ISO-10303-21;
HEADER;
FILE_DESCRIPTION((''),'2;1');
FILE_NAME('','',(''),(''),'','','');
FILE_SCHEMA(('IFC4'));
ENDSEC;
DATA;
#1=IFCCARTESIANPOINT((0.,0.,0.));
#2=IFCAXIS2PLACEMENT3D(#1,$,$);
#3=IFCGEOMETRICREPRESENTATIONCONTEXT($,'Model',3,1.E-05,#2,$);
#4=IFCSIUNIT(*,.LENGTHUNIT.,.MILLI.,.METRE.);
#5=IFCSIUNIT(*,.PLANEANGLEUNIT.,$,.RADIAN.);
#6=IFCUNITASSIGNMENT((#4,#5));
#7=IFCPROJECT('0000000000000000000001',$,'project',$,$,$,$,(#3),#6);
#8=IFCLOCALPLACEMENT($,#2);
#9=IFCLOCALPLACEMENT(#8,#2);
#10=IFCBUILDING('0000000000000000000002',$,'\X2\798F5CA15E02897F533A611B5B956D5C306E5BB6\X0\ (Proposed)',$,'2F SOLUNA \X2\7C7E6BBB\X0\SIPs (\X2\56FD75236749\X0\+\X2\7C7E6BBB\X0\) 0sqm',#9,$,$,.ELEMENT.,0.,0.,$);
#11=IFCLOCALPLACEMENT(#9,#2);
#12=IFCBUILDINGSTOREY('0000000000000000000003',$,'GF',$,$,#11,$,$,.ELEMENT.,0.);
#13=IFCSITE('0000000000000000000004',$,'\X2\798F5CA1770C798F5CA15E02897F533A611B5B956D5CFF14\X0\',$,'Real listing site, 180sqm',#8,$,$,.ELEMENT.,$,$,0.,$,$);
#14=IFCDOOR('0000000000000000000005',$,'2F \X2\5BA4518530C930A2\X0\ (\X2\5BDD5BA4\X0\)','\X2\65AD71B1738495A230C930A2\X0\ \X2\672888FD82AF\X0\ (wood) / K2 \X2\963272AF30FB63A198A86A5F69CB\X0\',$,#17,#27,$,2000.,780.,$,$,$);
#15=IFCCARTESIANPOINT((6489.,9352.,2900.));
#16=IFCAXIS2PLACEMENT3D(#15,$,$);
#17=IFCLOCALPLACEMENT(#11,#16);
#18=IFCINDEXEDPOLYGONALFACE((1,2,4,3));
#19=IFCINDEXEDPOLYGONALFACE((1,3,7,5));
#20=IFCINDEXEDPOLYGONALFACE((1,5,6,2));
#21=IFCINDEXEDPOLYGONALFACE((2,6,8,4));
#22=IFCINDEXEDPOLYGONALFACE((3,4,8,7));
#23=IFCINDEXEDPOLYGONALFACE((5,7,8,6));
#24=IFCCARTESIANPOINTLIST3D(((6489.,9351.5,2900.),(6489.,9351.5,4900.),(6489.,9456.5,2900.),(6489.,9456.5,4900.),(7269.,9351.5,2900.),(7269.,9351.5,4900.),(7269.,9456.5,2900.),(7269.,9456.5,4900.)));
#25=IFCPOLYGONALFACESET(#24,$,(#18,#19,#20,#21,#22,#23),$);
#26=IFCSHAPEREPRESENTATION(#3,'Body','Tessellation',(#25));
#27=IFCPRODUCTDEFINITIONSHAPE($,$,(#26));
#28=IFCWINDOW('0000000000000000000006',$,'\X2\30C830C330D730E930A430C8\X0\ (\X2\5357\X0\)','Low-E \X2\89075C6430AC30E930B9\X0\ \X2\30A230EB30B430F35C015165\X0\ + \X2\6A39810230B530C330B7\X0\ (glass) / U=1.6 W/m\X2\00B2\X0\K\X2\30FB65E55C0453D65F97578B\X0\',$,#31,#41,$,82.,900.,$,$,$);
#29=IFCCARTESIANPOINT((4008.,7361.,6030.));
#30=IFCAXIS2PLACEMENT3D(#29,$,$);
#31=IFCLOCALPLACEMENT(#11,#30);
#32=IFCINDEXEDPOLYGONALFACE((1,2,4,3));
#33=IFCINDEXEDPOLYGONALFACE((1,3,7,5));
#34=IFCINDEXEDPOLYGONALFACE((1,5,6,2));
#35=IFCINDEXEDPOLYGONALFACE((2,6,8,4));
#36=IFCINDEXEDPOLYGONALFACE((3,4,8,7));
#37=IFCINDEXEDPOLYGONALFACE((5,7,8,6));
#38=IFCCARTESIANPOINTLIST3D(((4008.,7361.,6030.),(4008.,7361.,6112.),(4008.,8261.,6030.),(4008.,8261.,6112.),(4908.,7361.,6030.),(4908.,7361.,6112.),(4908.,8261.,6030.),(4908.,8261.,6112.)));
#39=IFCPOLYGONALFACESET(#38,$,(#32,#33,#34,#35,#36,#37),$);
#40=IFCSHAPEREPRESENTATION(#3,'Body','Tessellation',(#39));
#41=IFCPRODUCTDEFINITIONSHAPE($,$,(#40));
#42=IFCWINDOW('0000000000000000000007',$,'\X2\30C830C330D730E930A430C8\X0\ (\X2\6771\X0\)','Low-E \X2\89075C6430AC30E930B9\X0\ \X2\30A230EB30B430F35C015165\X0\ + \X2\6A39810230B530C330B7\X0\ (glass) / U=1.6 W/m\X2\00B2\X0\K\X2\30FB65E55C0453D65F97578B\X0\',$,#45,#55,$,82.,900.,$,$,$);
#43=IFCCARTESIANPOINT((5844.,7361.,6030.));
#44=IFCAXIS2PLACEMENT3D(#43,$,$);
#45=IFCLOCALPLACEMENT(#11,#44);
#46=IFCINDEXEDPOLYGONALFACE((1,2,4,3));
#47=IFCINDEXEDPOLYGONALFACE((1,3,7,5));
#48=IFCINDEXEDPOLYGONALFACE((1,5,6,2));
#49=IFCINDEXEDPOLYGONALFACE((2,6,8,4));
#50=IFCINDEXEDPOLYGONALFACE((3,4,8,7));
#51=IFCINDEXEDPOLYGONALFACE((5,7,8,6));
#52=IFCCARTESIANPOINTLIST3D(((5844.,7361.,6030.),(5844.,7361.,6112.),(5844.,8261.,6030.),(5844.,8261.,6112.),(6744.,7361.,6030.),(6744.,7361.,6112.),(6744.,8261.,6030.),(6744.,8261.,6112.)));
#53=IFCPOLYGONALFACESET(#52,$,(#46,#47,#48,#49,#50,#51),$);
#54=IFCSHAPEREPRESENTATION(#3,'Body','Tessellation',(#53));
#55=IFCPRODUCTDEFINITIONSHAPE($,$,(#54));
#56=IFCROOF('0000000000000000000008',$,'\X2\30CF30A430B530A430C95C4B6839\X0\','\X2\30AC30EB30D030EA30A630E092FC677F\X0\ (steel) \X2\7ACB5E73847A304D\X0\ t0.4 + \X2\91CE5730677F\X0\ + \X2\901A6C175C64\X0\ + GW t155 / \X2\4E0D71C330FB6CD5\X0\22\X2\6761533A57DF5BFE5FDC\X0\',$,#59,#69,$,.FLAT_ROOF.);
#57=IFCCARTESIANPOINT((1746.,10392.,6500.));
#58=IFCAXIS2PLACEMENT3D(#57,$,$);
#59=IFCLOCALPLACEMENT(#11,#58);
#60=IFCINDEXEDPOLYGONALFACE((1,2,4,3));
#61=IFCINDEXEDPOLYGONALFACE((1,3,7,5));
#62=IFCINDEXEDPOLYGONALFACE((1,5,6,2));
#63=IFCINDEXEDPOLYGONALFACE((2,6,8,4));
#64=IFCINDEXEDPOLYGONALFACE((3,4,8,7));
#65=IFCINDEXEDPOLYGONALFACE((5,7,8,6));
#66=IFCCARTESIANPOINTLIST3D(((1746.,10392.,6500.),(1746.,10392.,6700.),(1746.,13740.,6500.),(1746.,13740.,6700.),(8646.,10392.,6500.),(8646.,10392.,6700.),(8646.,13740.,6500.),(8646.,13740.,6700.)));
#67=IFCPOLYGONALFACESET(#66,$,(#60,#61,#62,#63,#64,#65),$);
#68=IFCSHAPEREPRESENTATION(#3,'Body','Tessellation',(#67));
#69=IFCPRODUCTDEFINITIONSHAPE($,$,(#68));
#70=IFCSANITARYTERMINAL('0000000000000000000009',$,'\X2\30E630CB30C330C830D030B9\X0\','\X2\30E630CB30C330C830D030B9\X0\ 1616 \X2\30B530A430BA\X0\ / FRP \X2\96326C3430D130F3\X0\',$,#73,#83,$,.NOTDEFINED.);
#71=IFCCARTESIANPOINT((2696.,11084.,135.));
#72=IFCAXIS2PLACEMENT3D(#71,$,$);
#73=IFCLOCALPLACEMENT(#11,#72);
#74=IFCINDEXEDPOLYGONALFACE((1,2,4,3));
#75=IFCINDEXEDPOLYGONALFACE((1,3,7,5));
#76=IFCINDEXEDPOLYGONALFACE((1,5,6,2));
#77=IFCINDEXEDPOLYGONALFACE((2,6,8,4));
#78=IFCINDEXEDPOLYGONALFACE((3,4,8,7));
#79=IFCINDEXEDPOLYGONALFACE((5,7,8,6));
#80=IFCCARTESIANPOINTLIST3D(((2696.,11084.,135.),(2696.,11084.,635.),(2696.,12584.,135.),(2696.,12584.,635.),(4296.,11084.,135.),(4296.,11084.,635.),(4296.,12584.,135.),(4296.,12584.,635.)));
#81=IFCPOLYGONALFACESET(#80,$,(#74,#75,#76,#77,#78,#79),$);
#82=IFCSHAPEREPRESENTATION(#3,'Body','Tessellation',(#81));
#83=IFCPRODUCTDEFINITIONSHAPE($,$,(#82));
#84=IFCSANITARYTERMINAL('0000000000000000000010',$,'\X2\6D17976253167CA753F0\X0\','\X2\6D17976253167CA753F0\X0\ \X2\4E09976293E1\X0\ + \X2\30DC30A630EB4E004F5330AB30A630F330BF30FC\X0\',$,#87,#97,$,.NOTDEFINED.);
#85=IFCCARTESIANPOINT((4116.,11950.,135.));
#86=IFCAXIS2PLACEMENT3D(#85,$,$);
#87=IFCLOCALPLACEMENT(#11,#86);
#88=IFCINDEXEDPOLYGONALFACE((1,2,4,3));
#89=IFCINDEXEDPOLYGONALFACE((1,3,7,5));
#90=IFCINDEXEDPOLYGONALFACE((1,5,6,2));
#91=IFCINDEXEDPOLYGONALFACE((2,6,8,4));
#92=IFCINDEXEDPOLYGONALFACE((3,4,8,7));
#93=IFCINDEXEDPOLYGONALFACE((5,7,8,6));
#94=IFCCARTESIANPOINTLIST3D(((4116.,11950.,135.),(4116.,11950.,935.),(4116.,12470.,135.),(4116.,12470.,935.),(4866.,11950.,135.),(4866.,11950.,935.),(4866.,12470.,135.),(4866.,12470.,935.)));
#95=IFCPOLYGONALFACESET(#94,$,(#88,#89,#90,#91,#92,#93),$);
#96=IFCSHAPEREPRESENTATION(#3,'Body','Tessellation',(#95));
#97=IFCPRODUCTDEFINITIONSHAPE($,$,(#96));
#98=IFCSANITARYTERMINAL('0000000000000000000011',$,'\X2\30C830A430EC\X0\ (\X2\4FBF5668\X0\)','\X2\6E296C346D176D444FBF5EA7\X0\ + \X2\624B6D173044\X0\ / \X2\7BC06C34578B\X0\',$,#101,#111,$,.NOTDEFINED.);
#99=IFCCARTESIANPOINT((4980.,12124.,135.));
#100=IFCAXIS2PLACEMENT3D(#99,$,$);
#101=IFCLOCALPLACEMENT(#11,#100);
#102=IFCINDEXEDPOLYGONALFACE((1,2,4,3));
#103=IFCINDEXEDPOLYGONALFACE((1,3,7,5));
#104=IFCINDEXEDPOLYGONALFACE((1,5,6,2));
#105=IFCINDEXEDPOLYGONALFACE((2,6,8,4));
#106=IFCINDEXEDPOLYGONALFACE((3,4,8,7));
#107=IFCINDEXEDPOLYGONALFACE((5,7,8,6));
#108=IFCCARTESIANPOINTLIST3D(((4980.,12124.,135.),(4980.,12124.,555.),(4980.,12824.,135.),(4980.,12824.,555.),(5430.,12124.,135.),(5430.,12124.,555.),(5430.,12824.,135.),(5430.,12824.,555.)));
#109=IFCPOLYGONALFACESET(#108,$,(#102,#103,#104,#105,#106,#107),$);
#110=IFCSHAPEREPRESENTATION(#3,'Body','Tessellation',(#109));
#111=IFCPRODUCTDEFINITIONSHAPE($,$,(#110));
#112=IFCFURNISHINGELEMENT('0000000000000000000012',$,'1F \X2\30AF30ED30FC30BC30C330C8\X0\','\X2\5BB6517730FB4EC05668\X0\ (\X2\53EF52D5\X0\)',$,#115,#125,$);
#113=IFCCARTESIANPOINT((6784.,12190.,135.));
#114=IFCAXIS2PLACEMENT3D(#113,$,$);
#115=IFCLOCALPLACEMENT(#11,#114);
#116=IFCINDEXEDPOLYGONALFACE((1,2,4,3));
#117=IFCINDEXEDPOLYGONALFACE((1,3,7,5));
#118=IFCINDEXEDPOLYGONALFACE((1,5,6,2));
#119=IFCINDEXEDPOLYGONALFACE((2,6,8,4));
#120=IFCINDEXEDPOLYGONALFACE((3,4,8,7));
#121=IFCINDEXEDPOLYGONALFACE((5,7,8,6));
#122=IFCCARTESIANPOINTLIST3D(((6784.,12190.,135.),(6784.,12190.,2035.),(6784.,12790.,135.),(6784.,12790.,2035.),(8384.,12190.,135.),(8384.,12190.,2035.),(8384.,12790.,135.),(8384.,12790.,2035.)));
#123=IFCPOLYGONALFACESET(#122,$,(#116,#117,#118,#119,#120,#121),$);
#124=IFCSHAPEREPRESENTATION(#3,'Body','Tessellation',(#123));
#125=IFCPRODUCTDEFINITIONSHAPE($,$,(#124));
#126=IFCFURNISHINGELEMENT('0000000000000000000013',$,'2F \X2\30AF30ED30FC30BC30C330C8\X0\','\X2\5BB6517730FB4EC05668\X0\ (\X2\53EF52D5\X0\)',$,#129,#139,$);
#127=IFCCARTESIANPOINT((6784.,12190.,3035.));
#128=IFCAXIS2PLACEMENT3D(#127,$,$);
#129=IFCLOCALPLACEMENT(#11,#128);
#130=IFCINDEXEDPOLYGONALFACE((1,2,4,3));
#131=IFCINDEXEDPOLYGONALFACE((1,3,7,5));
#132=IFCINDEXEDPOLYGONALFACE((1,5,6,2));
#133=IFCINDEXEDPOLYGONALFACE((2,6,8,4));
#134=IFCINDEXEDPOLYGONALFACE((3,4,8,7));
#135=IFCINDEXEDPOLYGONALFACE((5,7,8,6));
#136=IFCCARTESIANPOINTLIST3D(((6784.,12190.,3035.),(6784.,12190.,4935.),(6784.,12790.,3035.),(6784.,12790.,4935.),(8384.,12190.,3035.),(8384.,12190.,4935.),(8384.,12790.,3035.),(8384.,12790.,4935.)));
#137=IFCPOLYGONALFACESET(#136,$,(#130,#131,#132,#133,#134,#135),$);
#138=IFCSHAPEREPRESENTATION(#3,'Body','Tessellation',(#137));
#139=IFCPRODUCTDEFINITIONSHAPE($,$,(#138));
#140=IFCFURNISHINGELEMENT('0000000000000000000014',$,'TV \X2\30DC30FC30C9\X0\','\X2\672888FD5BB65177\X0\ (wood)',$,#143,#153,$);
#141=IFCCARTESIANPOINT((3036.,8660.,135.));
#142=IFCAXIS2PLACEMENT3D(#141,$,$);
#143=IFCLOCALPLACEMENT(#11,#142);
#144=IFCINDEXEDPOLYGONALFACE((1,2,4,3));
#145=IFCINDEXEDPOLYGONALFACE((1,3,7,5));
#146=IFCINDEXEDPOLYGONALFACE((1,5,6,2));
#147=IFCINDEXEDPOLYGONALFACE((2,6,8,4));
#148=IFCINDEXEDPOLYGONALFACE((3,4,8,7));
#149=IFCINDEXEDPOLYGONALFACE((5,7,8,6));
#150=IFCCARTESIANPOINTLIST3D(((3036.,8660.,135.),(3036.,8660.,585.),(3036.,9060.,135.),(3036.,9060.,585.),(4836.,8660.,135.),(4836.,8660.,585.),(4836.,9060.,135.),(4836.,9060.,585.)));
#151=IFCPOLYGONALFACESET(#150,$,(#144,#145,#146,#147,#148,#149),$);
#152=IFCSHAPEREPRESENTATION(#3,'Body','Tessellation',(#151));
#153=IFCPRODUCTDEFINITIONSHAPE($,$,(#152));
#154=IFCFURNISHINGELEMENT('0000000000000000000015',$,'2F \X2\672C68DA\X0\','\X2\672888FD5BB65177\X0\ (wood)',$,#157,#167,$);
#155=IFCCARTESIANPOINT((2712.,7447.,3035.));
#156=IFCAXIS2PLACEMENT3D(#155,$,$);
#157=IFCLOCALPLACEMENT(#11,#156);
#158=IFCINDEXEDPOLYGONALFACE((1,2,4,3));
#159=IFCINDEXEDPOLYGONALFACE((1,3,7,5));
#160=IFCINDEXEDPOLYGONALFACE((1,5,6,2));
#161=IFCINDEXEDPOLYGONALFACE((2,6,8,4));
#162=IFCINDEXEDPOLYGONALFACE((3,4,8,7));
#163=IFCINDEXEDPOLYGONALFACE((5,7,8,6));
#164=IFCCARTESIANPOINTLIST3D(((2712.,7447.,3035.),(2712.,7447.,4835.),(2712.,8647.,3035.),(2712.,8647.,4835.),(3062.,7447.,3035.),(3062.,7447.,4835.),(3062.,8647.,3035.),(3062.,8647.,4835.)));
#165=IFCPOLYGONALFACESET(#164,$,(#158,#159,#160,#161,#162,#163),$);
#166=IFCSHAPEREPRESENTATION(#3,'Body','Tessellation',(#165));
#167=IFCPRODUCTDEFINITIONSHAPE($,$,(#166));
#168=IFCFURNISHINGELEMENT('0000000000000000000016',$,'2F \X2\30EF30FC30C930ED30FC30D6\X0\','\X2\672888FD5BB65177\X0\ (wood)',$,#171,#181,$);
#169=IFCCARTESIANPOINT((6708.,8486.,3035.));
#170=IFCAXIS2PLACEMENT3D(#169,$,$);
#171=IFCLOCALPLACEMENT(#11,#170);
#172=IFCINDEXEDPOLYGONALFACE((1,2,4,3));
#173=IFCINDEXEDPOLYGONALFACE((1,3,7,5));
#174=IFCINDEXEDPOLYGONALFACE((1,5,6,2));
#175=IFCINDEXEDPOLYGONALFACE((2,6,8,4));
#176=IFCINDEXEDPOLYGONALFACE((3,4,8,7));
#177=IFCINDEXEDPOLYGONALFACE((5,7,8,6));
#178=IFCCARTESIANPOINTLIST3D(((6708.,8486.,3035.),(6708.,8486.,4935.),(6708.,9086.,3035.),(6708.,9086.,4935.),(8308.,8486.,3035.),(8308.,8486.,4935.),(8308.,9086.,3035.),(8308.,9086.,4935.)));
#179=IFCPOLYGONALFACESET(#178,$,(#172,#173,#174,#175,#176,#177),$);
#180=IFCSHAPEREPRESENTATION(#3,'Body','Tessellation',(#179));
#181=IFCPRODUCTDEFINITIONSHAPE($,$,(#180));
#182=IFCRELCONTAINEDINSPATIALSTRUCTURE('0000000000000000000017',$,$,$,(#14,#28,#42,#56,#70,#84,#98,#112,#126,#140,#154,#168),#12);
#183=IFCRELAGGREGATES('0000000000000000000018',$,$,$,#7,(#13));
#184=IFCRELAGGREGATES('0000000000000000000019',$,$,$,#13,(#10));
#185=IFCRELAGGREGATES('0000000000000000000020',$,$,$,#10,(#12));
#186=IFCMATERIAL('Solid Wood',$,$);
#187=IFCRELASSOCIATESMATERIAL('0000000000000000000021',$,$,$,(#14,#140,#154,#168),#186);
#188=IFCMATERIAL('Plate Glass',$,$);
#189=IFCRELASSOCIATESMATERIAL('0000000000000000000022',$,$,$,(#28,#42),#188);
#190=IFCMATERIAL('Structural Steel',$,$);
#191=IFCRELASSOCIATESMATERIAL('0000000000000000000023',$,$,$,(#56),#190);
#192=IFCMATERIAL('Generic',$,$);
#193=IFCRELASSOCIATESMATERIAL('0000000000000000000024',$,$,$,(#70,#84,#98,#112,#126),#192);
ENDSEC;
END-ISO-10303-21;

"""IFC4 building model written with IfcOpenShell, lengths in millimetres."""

from ifc_helpers import new_model, si_unit, frame, frame_2d, origin, place, context, project, spatial, rectangle, extrude, material, element, save


model = new_model("IFC4")

# Units and contexts
model_context = context("Model", 3, precision=1e-05, world=origin())
ifc_project = project(units=[si_unit("LENGTHUNIT", "METRE", prefix="MILLI"), si_unit("PLANEANGLEUNIT", "RADIAN")], contexts=[model_context])

# Site, building, storey
site_placement = place(None, origin())
site = spatial("IfcSite", under=ifc_project, at=site_placement, Name="福岡県福岡市西区愛宕浜４", ObjectType="Real listing site, 180sqm", CompositionType="ELEMENT", RefElevation=0.0)
building_placement = place(site_placement, origin())
building = spatial("IfcBuilding", under=site, at=building_placement, Name="福岡市西区愛宕浜の家 (Proposed)", ObjectType="2F SOLUNA 籾殻SIPs (国産杉+籾殻) 0sqm", CompositionType="ELEMENT", ElevationOfRefHeight=0.0, ElevationOfTerrain=0.0)
storey_placement = place(building_placement, origin())
storey = spatial("IfcBuildingStorey", under=building, at=storey_placement, Name="GF", CompositionType="ELEMENT", Elevation=0.0)

# Shared definitions
ifc_material_1 = material(Name="Solid Wood")
ifc_material_2 = material(Name="Plate Glass")

# Door
door_1_placement = place(storey_placement, frame((6489.0, 9352.0, 2900.0)))
element("IfcDoor", 1, at=door_1_placement, inside=storey, material=ifc_material_1, Name="2F 室内ドア (寝室)", Description="断熱玄関ドア 木製芯 (wood) / K2 防犯・採風機構", OverallHeight=2000.0, OverallWidth=780.0, context=model_context, shape_type="SweptSolid", body=[
    extrude(rectangle(XDim=780.0, YDim=105.0, at=frame_2d((390.0, 52.0))), frame((6489.0, 9352.0, 2900.0)), (0.0, 0.0, 1.0), 2000.0),
])

# Windows
window_1_placement = place(storey_placement, frame((4008.0, 7361.0, 6030.0)))
element("IfcWindow", 2, at=window_1_placement, inside=storey, material=ifc_material_2, Name="トップライト (南)", Description="Low-E 複層ガラス アルゴン封入 + 樹脂サッシ (glass) / U=1.6 W/m²K・日射取得型", OverallHeight=82.0, OverallWidth=900.0, context=model_context, shape_type="SweptSolid", body=[
    extrude(rectangle(XDim=900.0, YDim=900.0, at=frame_2d((450.0, 450.0))), frame((4008.0, 7361.0, 6030.0)), (0.0, 0.0, 1.0), 82.0),
])
window_2_placement = place(storey_placement, frame((5844.0, 7361.0, 6030.0)))
element("IfcWindow", 3, at=window_2_placement, inside=storey, material=ifc_material_2, Name="トップライト (東)", Description="Low-E 複層ガラス アルゴン封入 + 樹脂サッシ (glass) / U=1.6 W/m²K・日射取得型", OverallHeight=82.0, OverallWidth=900.0, context=model_context, shape_type="SweptSolid", body=[
    extrude(rectangle(XDim=900.0, YDim=900.0, at=frame_2d((450.0, 450.0))), frame((5844.0, 7361.0, 6030.0)), (0.0, 0.0, 1.0), 82.0),
])

# Roof
ifc_material_3 = material(Name="Structural Steel")
roof_placement = place(storey_placement, frame((1746.0, 10392.0, 6500.0)))
element("IfcRoof", 4, at=roof_placement, inside=storey, material=ifc_material_3, Name="ハイサイド屋根", Description="ガルバリウム鋼板 (steel) 立平葺き t0.4 + 野地板 + 通気層 + GW t155 / 不燃・法22条区域対応", PredefinedType="FLAT_ROOF", context=model_context, shape_type="SweptSolid", body=[
    extrude(rectangle(XDim=6900.0, YDim=3348.0, at=frame_2d((3450.0, 1674.0))), frame((1746.0, 10392.0, 6500.0)), (0.0, 0.0, 1.0), 200.0),
])

# Sanitary terminals
ifc_material_4 = material(Name="Generic")
sanitary_terminal_1_placement = place(storey_placement, frame((2696.0, 11084.0, 135.0)))
element("IfcSanitaryTerminal", 5, at=sanitary_terminal_1_placement, inside=storey, material=ifc_material_4, Name="ユニットバス", Description="ユニットバス 1616 サイズ / FRP 防水パン", PredefinedType="NOTDEFINED", context=model_context, shape_type="SweptSolid", body=[
    extrude(rectangle(XDim=1600.0, YDim=1500.0, at=frame_2d((800.0, 750.0))), frame((2696.0, 11084.0, 135.0)), (0.0, 0.0, 1.0), 500.0),
])
sanitary_terminal_2_placement = place(storey_placement, frame((4116.0, 11950.0, 135.0)))
element("IfcSanitaryTerminal", 6, at=sanitary_terminal_2_placement, inside=storey, material=ifc_material_4, Name="洗面化粧台", Description="洗面化粧台 三面鏡 + ボウル一体カウンター", PredefinedType="NOTDEFINED", context=model_context, shape_type="SweptSolid", body=[
    extrude(rectangle(XDim=750.0, YDim=520.0, at=frame_2d((375.0, 260.0))), frame((4116.0, 11950.0, 135.0)), (0.0, 0.0, 1.0), 800.0),
])
sanitary_terminal_3_placement = place(storey_placement, frame((4980.0, 12124.0, 135.0)))
element("IfcSanitaryTerminal", 7, at=sanitary_terminal_3_placement, inside=storey, material=ifc_material_4, Name="トイレ (便器)", Description="温水洗浄便座 + 手洗い / 節水型", PredefinedType="NOTDEFINED", context=model_context, shape_type="SweptSolid", body=[
    extrude(rectangle(XDim=450.0, YDim=700.0, at=frame_2d((225.0, 350.0))), frame((4980.0, 12124.0, 135.0)), (0.0, 0.0, 1.0), 420.0),
])

# Furnishing elements
furnishing_1_placement = place(storey_placement, frame((6784.0, 12190.0, 135.0)))
element("IfcFurnishingElement", 8, at=furnishing_1_placement, inside=storey, material=ifc_material_4, Name="1F クローゼット", Description="家具・什器 (可動)", context=model_context, shape_type="SweptSolid", body=[
    extrude(rectangle(XDim=1600.0, YDim=600.0, at=frame_2d((800.0, 300.0))), frame((6784.0, 12190.0, 135.0)), (0.0, 0.0, 1.0), 1900.0),
])
furnishing_2_placement = place(storey_placement, frame((6784.0, 12190.0, 3035.0)))
element("IfcFurnishingElement", 9, at=furnishing_2_placement, inside=storey, material=ifc_material_4, Name="2F クローゼット", Description="家具・什器 (可動)", context=model_context, shape_type="SweptSolid", body=[
    extrude(rectangle(XDim=1600.0, YDim=600.0, at=frame_2d((800.0, 300.0))), frame((6784.0, 12190.0, 3035.0)), (0.0, 0.0, 1.0), 1900.0),
])
furnishing_3_placement = place(storey_placement, frame((3036.0, 8660.0, 135.0)))
element("IfcFurnishingElement", 10, at=furnishing_3_placement, inside=storey, material=ifc_material_1, Name="TV ボード", Description="木製家具 (wood)", context=model_context, shape_type="SweptSolid", body=[
    extrude(rectangle(XDim=1800.0, YDim=400.0, at=frame_2d((900.0, 200.0))), frame((3036.0, 8660.0, 135.0)), (0.0, 0.0, 1.0), 450.0),
])
furnishing_4_placement = place(storey_placement, frame((2712.0, 7447.0, 3035.0)))
element("IfcFurnishingElement", 11, at=furnishing_4_placement, inside=storey, material=ifc_material_1, Name="2F 本棚", Description="木製家具 (wood)", context=model_context, shape_type="SweptSolid", body=[
    extrude(rectangle(XDim=350.0, YDim=1200.0, at=frame_2d((175.0, 600.0))), frame((2712.0, 7447.0, 3035.0)), (0.0, 0.0, 1.0), 1800.0),
])
furnishing_5_placement = place(storey_placement, frame((6708.0, 8486.0, 3035.0)))
element("IfcFurnishingElement", 12, at=furnishing_5_placement, inside=storey, material=ifc_material_1, Name="2F ワードローブ", Description="木製家具 (wood)", context=model_context, shape_type="SweptSolid", body=[
    extrude(rectangle(XDim=1600.0, YDim=600.0, at=frame_2d((800.0, 300.0))), frame((6708.0, 8486.0, 3035.0)), (0.0, 0.0, 1.0), 1900.0),
])

save(model, "model.ifc")
